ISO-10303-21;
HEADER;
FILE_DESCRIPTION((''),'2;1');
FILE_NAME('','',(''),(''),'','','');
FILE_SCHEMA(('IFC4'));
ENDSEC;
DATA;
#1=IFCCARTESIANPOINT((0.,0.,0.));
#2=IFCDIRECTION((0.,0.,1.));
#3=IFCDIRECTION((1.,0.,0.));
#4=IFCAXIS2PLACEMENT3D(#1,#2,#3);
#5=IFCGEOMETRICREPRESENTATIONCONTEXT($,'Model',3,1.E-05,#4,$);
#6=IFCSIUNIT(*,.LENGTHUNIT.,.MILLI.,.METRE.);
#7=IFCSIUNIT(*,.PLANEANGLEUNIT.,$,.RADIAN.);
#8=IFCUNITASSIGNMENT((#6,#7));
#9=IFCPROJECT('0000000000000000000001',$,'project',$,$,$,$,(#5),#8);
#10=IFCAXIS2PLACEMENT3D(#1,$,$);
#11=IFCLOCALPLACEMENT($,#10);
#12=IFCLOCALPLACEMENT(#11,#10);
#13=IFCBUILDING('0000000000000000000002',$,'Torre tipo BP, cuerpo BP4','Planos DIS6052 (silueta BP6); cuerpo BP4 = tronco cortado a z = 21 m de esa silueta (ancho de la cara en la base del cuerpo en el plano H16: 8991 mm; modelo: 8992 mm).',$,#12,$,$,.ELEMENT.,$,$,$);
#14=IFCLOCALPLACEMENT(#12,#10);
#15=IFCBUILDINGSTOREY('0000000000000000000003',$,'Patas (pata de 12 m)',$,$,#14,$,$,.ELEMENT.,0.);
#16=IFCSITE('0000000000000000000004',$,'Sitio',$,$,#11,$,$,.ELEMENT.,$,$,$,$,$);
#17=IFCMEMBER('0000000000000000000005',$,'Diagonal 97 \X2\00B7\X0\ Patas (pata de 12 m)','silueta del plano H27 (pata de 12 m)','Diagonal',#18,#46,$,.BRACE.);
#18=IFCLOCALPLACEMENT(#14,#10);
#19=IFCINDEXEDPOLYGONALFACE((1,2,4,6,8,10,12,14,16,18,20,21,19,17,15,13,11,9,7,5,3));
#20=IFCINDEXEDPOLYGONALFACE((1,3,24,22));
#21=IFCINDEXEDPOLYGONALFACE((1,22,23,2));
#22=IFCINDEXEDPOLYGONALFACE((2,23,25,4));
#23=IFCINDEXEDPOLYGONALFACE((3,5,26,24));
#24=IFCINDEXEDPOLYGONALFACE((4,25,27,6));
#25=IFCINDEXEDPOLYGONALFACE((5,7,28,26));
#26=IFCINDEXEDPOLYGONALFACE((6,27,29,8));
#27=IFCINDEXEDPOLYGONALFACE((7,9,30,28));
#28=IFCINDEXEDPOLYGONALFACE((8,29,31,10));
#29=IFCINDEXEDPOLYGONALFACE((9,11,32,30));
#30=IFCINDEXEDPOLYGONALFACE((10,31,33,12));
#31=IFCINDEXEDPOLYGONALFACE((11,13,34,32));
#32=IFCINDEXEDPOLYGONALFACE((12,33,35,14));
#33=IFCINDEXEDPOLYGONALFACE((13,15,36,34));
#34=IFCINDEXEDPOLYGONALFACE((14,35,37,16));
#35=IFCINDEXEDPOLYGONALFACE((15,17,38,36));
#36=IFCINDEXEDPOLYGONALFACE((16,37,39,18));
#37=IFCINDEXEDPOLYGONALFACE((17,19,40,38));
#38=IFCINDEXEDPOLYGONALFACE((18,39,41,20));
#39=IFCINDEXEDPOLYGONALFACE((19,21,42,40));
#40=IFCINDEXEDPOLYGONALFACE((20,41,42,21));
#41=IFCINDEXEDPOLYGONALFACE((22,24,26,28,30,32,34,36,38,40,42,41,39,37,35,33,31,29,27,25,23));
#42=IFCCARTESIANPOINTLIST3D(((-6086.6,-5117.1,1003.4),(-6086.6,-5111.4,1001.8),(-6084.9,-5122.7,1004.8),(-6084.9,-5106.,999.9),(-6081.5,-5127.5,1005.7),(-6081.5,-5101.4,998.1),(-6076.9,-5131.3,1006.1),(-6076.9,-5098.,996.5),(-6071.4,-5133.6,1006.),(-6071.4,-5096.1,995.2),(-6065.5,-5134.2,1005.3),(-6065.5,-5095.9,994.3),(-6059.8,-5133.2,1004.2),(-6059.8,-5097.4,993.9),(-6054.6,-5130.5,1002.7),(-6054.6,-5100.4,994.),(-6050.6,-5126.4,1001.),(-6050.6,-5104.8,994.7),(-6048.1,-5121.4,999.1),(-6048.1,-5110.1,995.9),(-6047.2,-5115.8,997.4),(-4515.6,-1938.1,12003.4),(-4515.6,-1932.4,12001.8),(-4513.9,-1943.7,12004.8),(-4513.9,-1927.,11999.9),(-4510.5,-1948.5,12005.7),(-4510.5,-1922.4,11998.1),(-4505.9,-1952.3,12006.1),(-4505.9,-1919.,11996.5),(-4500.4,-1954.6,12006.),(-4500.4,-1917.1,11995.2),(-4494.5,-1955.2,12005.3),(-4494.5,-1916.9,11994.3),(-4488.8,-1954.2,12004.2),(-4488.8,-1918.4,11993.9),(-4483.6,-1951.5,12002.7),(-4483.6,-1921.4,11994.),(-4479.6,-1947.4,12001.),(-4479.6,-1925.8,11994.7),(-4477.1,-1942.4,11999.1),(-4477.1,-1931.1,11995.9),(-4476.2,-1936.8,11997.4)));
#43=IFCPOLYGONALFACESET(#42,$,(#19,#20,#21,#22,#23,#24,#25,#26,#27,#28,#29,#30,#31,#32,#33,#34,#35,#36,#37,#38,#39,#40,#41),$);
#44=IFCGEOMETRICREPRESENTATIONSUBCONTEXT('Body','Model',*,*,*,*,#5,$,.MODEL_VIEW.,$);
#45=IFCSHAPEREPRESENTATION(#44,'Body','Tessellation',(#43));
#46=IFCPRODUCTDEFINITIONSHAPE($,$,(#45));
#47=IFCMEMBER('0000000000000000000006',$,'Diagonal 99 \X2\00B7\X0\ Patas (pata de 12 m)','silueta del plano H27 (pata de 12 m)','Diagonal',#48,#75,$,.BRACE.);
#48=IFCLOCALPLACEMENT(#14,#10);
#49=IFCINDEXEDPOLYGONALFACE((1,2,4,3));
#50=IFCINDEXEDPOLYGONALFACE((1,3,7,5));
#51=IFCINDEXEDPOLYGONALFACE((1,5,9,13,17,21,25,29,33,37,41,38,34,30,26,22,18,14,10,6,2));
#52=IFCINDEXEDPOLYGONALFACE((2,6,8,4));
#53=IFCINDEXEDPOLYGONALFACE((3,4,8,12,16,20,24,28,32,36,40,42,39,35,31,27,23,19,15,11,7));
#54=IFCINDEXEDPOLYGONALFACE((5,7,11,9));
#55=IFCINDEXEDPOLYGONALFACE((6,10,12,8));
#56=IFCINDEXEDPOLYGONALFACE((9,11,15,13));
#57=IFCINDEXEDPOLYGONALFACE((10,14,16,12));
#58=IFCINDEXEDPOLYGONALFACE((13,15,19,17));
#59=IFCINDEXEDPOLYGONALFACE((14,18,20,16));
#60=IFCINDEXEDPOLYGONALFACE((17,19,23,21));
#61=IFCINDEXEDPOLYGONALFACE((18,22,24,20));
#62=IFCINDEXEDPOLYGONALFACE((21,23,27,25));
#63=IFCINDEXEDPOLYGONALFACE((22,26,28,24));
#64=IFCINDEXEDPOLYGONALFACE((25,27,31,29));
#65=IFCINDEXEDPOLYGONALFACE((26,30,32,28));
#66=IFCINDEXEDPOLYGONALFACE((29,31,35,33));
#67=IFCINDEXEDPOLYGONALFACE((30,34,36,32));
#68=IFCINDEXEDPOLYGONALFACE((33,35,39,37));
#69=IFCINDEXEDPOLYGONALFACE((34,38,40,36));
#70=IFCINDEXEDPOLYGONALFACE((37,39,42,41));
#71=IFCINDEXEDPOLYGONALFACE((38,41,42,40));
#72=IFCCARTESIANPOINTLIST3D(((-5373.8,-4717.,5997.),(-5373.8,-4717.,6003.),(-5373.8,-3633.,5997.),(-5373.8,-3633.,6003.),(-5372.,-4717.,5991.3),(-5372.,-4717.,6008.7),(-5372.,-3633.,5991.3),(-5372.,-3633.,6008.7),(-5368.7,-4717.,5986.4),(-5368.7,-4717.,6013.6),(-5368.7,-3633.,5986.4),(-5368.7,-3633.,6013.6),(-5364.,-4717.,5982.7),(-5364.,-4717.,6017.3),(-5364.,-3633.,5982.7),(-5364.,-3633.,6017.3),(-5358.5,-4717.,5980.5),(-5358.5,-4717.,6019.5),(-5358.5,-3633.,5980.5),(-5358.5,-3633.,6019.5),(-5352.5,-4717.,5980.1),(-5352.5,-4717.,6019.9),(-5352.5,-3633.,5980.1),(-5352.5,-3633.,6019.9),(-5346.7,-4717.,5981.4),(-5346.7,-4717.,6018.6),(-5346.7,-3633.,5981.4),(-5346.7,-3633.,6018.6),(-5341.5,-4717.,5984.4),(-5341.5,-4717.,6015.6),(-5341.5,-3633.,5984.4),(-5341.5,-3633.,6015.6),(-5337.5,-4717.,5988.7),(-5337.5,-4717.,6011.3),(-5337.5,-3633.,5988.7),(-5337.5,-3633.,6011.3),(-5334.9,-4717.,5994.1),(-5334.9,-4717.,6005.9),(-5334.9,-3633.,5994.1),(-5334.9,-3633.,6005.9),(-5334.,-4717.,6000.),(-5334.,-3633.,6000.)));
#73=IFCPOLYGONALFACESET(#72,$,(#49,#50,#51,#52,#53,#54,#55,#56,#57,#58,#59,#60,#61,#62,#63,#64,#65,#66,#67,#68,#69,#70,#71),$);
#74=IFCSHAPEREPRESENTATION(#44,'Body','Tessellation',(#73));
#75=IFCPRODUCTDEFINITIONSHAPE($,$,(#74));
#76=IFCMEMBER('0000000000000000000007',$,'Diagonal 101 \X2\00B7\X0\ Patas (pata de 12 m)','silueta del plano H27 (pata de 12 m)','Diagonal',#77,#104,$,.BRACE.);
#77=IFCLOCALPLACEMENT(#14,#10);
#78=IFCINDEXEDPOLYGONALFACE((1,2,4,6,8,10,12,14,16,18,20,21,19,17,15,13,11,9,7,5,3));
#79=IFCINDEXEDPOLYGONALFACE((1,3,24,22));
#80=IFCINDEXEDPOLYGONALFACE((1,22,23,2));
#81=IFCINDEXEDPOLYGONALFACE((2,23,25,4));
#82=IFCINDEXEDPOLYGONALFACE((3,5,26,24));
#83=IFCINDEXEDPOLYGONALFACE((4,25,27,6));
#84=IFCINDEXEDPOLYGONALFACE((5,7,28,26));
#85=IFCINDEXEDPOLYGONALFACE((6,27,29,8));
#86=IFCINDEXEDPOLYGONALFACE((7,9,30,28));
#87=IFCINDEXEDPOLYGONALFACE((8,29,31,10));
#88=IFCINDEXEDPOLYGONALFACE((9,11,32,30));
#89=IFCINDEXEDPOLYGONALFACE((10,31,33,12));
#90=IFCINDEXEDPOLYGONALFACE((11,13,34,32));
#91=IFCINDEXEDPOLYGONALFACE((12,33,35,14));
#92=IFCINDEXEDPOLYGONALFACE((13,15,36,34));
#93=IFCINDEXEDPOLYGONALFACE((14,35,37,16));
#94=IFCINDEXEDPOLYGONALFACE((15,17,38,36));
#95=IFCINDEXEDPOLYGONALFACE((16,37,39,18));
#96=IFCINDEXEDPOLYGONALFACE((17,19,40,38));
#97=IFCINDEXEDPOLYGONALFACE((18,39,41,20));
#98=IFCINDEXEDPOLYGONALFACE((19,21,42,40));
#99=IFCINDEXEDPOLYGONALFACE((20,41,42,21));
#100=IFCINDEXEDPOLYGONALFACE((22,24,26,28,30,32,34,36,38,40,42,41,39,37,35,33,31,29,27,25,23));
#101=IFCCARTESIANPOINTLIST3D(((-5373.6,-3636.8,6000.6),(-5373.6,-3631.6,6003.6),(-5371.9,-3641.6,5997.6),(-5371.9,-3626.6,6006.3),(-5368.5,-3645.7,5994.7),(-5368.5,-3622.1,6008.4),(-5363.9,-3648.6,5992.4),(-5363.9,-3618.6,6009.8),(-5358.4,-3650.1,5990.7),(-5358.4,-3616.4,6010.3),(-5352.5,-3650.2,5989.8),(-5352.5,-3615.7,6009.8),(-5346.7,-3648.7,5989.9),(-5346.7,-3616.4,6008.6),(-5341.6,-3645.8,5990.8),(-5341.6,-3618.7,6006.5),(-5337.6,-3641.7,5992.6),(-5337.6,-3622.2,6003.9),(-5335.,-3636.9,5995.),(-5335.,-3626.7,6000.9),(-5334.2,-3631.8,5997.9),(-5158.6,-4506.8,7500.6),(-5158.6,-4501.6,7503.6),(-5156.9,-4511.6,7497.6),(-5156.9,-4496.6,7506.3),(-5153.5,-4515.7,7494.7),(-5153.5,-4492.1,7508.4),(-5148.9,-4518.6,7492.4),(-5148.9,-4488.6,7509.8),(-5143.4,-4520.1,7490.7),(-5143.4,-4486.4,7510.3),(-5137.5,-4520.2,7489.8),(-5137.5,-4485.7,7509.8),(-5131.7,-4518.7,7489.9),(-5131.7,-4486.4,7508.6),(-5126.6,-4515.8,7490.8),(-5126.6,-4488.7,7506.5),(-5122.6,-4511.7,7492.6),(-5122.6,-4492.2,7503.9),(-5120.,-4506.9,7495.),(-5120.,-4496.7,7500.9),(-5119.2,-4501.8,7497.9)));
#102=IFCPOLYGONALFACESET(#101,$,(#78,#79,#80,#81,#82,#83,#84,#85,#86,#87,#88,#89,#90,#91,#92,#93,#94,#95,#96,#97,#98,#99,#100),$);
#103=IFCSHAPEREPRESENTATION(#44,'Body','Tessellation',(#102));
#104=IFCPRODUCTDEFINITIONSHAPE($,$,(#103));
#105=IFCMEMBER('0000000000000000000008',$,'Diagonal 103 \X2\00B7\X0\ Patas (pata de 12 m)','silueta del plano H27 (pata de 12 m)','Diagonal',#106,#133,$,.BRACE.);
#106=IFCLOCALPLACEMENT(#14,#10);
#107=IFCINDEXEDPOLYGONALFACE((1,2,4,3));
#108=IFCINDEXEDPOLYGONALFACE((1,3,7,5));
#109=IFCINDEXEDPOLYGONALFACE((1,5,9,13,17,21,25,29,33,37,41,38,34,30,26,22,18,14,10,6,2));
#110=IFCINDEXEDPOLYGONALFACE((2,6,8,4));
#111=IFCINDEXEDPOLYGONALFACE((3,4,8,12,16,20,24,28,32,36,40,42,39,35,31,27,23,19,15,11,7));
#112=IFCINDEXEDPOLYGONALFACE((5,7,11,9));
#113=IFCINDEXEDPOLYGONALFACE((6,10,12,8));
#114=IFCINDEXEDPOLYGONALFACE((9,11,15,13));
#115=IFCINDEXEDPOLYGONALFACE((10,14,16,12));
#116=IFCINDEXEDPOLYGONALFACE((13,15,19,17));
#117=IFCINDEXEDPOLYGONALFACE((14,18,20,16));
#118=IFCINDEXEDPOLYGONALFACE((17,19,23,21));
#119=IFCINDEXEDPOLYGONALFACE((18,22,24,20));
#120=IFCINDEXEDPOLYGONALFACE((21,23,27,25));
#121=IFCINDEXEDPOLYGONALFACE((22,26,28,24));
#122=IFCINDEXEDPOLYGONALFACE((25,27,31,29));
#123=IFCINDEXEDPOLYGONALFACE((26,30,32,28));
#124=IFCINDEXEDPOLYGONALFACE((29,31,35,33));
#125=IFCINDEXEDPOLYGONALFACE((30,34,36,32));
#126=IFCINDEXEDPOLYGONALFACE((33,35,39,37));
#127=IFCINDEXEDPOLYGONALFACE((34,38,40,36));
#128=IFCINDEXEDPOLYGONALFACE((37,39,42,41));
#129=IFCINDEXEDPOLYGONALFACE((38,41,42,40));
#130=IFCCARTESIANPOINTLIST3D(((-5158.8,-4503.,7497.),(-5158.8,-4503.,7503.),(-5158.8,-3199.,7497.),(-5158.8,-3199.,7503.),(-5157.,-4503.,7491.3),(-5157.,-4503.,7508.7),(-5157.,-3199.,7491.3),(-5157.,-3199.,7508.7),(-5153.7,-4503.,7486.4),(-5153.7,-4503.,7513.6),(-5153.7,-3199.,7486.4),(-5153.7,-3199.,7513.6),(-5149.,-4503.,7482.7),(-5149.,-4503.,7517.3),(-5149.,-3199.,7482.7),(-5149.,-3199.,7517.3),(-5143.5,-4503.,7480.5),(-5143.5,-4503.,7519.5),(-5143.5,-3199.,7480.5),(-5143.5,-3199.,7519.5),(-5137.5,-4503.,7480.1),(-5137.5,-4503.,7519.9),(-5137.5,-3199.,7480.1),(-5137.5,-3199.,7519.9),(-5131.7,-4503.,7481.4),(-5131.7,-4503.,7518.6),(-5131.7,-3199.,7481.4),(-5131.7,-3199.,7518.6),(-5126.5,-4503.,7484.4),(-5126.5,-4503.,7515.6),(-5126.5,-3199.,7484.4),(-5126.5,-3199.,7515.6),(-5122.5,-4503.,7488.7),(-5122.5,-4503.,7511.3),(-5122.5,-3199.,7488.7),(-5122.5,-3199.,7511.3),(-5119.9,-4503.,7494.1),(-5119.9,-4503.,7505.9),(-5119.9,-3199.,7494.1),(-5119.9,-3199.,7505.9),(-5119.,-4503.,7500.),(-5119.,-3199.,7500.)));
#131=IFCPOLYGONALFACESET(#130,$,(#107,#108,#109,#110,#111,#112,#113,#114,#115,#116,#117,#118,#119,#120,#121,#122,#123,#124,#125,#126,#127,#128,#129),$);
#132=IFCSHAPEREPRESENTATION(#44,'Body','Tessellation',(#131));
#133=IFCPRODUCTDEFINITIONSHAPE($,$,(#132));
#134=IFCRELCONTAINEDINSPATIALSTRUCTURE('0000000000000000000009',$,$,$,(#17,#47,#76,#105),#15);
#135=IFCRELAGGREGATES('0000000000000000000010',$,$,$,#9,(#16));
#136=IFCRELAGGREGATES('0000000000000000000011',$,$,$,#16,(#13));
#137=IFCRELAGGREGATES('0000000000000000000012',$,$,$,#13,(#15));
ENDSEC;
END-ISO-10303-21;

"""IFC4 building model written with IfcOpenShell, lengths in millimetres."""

from ifc_helpers import new_model, si_unit, frame, origin, origin_with_axes, place, context, subcontext, project, spatial, circle, extrude, element, save


model = new_model("IFC4")

# Units and contexts
model_context = context("Model", 3, precision=1e-05, world=origin_with_axes())
body_context = subcontext(model_context, "Body", "Model", "MODEL_VIEW")
ifc_project = project(units=[si_unit("LENGTHUNIT", "METRE", prefix="MILLI"), si_unit("PLANEANGLEUNIT", "RADIAN")], contexts=[model_context])

# Site, building, storey
site_placement = place(None, origin())
site = spatial("IfcSite", under=ifc_project, at=site_placement, Name="Sitio", CompositionType="ELEMENT")
building_placement = place(site_placement, origin())
building = spatial("IfcBuilding", under=site, at=building_placement, Name="Torre tipo BP, cuerpo BP4", Description="Planos DIS6052 (silueta BP6); cuerpo BP4 = tronco cortado a z = 21 m de esa silueta (ancho de la cara en la base del cuerpo en el plano H16: 8991 mm; modelo: 8992 mm).", CompositionType="ELEMENT")
storey_placement = place(building_placement, origin())
storey = spatial("IfcBuildingStorey", under=building, at=storey_placement, Name="Patas (pata de 12 m)", CompositionType="ELEMENT", Elevation=0.0)

# Members
member_1_placement = place(storey_placement, frame((-4496.0, -1936.0, 12000.0), z_axis=(-0.13593, -0.275061, -0.951769), x_axis=(0.990718, -0.037739, -0.130586)))
element("IfcMember", 1, at=member_1_placement, inside=storey, Name="Diagonal 97 · Patas (pata de 12 m)", Description="silueta del plano H27 (pata de 12 m)", ObjectType="Diagonal", PredefinedType="BRACE", context=body_context, shape_type="SweptSolid", body=[
    extrude(circle(Radius=20.0), None, (0.0, 0.0, 1.0), 11557.4),
])
member_2_placement = place(storey_placement, frame((-5354.0, -4717.0, 6000.0), z_axis=(0.0, 1.0, 0.0), x_axis=(1.0, 0.0, 0.0)))
element("IfcMember", 2, at=member_2_placement, inside=storey, Name="Diagonal 99 · Patas (pata de 12 m)", Description="silueta del plano H27 (pata de 12 m)", ObjectType="Diagonal", PredefinedType="BRACE", context=body_context, shape_type="SweptSolid", body=[
    extrude(circle(Radius=20.0), None, (0.0, 0.0, 1.0), 1084.0),
])
member_3_placement = place(storey_placement, frame((-5354.0, -3633.0, 6000.0), z_axis=(0.123046, -0.497906, 0.858458), x_axis=(0.992401, 0.061734, -0.106438)))
element("IfcMember", 3, at=member_3_placement, inside=storey, Name="Diagonal 101 · Patas (pata de 12 m)", Description="silueta del plano H27 (pata de 12 m)", ObjectType="Diagonal", PredefinedType="BRACE", context=body_context, shape_type="SweptSolid", body=[
    extrude(circle(Radius=20.0), None, (0.0, 0.0, 1.0), 1747.3),
])
member_4_placement = place(storey_placement, frame((-5139.0, -4503.0, 7500.0), z_axis=(0.0, 1.0, 0.0), x_axis=(1.0, 0.0, 0.0)))
element("IfcMember", 4, at=member_4_placement, inside=storey, Name="Diagonal 103 · Patas (pata de 12 m)", Description="silueta del plano H27 (pata de 12 m)", ObjectType="Diagonal", PredefinedType="BRACE", context=body_context, shape_type="SweptSolid", body=[
    extrude(circle(Radius=20.0), None, (0.0, 0.0, 1.0), 1304.0),
])

save(model, "model.ifc")
